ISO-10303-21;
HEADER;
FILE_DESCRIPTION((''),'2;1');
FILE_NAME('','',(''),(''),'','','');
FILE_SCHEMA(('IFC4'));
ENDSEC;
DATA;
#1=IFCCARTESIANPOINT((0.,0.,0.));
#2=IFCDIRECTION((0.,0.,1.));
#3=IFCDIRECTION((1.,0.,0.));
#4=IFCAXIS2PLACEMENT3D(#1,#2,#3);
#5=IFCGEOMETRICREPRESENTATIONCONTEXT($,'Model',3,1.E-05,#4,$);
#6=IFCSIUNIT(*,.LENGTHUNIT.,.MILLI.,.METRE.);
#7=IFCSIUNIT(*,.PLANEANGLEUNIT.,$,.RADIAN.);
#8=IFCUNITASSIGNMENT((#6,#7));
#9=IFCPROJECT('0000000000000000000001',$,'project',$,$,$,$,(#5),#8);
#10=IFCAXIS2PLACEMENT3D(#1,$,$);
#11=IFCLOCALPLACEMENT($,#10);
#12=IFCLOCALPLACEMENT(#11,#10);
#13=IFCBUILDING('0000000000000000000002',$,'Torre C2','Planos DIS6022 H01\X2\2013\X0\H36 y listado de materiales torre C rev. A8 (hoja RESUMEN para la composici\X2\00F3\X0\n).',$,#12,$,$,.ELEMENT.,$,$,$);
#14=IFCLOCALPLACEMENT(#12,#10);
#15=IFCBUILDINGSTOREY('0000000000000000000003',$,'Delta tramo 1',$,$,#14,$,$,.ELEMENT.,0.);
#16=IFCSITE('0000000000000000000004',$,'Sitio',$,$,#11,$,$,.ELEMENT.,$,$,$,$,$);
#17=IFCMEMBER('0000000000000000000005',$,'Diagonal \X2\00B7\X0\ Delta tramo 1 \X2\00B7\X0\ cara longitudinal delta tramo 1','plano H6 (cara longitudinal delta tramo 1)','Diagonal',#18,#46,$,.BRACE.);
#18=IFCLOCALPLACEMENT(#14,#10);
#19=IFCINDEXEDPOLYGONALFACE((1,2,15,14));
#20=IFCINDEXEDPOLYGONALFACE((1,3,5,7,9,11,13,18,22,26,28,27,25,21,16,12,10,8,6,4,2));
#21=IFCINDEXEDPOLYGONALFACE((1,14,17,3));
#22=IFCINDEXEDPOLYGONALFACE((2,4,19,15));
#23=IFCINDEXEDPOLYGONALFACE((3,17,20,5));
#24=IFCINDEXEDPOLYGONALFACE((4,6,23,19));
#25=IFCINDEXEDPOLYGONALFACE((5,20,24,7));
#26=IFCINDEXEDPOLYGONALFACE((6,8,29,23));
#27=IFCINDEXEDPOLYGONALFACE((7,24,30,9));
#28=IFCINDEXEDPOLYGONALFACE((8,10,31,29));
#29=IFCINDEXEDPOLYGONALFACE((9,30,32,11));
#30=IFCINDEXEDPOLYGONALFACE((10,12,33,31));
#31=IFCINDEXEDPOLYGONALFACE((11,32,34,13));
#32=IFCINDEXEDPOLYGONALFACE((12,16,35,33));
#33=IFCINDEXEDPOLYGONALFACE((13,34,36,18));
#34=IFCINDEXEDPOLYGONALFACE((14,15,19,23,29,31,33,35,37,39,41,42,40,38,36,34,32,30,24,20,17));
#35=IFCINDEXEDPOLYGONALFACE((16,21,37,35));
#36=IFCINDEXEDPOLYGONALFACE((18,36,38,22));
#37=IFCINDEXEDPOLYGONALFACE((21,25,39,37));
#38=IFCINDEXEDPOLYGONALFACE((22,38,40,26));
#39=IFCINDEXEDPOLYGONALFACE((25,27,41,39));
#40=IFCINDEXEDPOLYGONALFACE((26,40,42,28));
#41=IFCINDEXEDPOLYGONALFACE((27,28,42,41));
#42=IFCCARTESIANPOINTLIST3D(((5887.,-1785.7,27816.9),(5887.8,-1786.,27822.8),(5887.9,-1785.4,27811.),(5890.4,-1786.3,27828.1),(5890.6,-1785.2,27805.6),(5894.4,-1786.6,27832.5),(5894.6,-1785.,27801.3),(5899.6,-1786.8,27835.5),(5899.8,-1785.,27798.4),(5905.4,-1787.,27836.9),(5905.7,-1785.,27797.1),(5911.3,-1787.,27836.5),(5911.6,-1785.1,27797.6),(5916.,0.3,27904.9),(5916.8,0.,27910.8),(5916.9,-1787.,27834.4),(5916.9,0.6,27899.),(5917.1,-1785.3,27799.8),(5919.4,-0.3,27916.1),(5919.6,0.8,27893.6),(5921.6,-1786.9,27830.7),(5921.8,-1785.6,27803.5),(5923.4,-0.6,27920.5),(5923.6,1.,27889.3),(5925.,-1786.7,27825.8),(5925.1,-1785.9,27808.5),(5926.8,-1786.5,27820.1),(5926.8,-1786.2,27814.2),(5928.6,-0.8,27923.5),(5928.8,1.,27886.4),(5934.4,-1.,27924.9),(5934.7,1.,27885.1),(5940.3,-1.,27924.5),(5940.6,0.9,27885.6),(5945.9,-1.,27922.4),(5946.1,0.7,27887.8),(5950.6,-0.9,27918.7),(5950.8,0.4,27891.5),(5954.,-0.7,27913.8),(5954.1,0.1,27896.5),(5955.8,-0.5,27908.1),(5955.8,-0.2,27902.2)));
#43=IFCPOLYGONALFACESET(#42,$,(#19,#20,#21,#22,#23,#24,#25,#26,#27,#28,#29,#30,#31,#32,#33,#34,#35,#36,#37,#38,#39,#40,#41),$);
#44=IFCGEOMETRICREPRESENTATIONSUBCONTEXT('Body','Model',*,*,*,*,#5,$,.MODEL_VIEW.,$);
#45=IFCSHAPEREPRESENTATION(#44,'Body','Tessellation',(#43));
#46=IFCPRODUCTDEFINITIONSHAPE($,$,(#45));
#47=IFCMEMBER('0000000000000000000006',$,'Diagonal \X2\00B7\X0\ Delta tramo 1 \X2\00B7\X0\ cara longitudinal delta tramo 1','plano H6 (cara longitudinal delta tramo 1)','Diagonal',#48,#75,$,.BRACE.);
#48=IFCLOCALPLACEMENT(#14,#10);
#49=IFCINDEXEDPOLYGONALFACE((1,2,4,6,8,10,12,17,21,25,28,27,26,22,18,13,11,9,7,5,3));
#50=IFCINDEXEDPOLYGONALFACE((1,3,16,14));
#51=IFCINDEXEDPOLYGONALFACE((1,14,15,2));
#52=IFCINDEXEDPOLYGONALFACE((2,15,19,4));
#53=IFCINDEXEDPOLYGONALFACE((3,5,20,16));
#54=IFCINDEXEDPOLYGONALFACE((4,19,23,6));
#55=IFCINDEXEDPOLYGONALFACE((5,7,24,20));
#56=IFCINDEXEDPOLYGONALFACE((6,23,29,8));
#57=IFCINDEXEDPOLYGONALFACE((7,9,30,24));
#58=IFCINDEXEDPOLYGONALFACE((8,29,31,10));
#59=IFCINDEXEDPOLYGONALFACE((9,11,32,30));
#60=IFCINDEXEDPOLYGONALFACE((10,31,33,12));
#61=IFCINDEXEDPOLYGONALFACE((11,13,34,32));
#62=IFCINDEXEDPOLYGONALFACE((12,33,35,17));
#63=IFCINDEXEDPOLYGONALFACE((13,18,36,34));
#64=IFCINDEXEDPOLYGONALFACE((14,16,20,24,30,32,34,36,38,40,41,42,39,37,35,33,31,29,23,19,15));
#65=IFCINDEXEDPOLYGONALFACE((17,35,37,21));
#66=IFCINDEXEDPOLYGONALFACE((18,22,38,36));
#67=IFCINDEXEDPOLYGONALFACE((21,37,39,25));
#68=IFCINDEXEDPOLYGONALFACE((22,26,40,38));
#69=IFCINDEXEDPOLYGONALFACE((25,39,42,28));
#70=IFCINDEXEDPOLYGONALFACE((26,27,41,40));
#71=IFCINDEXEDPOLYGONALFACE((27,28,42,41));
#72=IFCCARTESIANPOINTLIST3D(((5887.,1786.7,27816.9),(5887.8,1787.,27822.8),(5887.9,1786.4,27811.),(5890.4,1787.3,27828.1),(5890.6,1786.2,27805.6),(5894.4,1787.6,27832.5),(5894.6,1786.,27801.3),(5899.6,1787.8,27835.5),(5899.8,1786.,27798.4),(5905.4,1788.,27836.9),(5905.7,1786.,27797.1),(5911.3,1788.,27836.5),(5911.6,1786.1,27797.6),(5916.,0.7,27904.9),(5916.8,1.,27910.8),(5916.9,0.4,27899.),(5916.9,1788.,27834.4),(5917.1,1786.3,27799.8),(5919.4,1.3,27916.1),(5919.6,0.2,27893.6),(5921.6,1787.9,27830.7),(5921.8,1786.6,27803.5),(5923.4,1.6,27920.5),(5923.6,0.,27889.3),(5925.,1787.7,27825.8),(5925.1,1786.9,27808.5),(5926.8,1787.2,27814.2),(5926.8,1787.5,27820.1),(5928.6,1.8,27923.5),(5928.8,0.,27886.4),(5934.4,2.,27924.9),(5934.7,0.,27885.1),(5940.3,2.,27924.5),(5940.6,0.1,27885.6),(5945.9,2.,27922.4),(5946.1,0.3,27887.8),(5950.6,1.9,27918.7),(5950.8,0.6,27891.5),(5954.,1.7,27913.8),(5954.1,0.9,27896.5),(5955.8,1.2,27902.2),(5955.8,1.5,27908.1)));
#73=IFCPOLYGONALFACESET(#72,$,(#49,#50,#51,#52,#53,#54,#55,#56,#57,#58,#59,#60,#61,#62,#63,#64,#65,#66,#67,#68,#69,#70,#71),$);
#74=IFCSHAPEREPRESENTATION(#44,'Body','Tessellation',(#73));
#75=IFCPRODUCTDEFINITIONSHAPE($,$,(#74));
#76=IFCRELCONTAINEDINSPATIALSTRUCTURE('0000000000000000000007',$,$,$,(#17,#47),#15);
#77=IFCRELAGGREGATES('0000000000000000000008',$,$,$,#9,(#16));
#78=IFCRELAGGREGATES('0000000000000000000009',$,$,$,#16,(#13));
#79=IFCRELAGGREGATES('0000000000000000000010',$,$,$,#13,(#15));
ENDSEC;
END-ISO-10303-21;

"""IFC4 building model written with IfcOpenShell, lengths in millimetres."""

from ifc_helpers import new_model, si_unit, frame, origin, origin_with_axes, place, context, subcontext, project, spatial, circle, extrude, element, save


model = new_model("IFC4")

# Units and contexts
model_context = context("Model", 3, precision=1e-05, world=origin_with_axes())
body_context = subcontext(model_context, "Body", "Model", "MODEL_VIEW")
ifc_project = project(units=[si_unit("LENGTHUNIT", "METRE", prefix="MILLI"), si_unit("PLANEANGLEUNIT", "RADIAN")], contexts=[model_context])

# Site, building, storey
site_placement = place(None, origin())
site = spatial("IfcSite", under=ifc_project, at=site_placement, Name="Sitio", CompositionType="ELEMENT")
building_placement = place(site_placement, origin())
building = spatial("IfcBuilding", under=site, at=building_placement, Name="Torre C2", Description="Planos DIS6022 H01–H36 y listado de materiales torre C rev. A8 (hoja RESUMEN para la composición).", CompositionType="ELEMENT")
storey_placement = place(building_placement, origin())
storey = spatial("IfcBuildingStorey", under=building, at=storey_placement, Name="Delta tramo 1", CompositionType="ELEMENT", Elevation=0.0)

# Members
for number, where, z_axis, x_axis, name in (
    (1, (5936.0, 0.0, 27905.0), (-0.016216, -0.998657, -0.049206), (-0.999841, 0.01656, -0.006597), "Diagonal · Delta tramo 1 · cara longitudinal delta tramo 1"),
    (2, (5936.0, 1.0, 27905.0), (-0.016216, 0.998657, -0.049206), (-0.999841, -0.01656, -0.006606), "Diagonal · Delta tramo 1 · cara longitudinal delta tramo 1"),
):
    element("IfcMember", number, at=place(storey_placement, frame(where, z_axis=z_axis, x_axis=x_axis)), inside=storey, Name=name, Description="plano H6 (cara longitudinal delta tramo 1)", ObjectType="Diagonal", PredefinedType="BRACE", context=body_context, shape_type="SweptSolid", body=[
        extrude(circle(Radius=20.0), None, (0.0, 0.0, 1.0), 1788.4),
    ])

save(model, "model.ifc")
